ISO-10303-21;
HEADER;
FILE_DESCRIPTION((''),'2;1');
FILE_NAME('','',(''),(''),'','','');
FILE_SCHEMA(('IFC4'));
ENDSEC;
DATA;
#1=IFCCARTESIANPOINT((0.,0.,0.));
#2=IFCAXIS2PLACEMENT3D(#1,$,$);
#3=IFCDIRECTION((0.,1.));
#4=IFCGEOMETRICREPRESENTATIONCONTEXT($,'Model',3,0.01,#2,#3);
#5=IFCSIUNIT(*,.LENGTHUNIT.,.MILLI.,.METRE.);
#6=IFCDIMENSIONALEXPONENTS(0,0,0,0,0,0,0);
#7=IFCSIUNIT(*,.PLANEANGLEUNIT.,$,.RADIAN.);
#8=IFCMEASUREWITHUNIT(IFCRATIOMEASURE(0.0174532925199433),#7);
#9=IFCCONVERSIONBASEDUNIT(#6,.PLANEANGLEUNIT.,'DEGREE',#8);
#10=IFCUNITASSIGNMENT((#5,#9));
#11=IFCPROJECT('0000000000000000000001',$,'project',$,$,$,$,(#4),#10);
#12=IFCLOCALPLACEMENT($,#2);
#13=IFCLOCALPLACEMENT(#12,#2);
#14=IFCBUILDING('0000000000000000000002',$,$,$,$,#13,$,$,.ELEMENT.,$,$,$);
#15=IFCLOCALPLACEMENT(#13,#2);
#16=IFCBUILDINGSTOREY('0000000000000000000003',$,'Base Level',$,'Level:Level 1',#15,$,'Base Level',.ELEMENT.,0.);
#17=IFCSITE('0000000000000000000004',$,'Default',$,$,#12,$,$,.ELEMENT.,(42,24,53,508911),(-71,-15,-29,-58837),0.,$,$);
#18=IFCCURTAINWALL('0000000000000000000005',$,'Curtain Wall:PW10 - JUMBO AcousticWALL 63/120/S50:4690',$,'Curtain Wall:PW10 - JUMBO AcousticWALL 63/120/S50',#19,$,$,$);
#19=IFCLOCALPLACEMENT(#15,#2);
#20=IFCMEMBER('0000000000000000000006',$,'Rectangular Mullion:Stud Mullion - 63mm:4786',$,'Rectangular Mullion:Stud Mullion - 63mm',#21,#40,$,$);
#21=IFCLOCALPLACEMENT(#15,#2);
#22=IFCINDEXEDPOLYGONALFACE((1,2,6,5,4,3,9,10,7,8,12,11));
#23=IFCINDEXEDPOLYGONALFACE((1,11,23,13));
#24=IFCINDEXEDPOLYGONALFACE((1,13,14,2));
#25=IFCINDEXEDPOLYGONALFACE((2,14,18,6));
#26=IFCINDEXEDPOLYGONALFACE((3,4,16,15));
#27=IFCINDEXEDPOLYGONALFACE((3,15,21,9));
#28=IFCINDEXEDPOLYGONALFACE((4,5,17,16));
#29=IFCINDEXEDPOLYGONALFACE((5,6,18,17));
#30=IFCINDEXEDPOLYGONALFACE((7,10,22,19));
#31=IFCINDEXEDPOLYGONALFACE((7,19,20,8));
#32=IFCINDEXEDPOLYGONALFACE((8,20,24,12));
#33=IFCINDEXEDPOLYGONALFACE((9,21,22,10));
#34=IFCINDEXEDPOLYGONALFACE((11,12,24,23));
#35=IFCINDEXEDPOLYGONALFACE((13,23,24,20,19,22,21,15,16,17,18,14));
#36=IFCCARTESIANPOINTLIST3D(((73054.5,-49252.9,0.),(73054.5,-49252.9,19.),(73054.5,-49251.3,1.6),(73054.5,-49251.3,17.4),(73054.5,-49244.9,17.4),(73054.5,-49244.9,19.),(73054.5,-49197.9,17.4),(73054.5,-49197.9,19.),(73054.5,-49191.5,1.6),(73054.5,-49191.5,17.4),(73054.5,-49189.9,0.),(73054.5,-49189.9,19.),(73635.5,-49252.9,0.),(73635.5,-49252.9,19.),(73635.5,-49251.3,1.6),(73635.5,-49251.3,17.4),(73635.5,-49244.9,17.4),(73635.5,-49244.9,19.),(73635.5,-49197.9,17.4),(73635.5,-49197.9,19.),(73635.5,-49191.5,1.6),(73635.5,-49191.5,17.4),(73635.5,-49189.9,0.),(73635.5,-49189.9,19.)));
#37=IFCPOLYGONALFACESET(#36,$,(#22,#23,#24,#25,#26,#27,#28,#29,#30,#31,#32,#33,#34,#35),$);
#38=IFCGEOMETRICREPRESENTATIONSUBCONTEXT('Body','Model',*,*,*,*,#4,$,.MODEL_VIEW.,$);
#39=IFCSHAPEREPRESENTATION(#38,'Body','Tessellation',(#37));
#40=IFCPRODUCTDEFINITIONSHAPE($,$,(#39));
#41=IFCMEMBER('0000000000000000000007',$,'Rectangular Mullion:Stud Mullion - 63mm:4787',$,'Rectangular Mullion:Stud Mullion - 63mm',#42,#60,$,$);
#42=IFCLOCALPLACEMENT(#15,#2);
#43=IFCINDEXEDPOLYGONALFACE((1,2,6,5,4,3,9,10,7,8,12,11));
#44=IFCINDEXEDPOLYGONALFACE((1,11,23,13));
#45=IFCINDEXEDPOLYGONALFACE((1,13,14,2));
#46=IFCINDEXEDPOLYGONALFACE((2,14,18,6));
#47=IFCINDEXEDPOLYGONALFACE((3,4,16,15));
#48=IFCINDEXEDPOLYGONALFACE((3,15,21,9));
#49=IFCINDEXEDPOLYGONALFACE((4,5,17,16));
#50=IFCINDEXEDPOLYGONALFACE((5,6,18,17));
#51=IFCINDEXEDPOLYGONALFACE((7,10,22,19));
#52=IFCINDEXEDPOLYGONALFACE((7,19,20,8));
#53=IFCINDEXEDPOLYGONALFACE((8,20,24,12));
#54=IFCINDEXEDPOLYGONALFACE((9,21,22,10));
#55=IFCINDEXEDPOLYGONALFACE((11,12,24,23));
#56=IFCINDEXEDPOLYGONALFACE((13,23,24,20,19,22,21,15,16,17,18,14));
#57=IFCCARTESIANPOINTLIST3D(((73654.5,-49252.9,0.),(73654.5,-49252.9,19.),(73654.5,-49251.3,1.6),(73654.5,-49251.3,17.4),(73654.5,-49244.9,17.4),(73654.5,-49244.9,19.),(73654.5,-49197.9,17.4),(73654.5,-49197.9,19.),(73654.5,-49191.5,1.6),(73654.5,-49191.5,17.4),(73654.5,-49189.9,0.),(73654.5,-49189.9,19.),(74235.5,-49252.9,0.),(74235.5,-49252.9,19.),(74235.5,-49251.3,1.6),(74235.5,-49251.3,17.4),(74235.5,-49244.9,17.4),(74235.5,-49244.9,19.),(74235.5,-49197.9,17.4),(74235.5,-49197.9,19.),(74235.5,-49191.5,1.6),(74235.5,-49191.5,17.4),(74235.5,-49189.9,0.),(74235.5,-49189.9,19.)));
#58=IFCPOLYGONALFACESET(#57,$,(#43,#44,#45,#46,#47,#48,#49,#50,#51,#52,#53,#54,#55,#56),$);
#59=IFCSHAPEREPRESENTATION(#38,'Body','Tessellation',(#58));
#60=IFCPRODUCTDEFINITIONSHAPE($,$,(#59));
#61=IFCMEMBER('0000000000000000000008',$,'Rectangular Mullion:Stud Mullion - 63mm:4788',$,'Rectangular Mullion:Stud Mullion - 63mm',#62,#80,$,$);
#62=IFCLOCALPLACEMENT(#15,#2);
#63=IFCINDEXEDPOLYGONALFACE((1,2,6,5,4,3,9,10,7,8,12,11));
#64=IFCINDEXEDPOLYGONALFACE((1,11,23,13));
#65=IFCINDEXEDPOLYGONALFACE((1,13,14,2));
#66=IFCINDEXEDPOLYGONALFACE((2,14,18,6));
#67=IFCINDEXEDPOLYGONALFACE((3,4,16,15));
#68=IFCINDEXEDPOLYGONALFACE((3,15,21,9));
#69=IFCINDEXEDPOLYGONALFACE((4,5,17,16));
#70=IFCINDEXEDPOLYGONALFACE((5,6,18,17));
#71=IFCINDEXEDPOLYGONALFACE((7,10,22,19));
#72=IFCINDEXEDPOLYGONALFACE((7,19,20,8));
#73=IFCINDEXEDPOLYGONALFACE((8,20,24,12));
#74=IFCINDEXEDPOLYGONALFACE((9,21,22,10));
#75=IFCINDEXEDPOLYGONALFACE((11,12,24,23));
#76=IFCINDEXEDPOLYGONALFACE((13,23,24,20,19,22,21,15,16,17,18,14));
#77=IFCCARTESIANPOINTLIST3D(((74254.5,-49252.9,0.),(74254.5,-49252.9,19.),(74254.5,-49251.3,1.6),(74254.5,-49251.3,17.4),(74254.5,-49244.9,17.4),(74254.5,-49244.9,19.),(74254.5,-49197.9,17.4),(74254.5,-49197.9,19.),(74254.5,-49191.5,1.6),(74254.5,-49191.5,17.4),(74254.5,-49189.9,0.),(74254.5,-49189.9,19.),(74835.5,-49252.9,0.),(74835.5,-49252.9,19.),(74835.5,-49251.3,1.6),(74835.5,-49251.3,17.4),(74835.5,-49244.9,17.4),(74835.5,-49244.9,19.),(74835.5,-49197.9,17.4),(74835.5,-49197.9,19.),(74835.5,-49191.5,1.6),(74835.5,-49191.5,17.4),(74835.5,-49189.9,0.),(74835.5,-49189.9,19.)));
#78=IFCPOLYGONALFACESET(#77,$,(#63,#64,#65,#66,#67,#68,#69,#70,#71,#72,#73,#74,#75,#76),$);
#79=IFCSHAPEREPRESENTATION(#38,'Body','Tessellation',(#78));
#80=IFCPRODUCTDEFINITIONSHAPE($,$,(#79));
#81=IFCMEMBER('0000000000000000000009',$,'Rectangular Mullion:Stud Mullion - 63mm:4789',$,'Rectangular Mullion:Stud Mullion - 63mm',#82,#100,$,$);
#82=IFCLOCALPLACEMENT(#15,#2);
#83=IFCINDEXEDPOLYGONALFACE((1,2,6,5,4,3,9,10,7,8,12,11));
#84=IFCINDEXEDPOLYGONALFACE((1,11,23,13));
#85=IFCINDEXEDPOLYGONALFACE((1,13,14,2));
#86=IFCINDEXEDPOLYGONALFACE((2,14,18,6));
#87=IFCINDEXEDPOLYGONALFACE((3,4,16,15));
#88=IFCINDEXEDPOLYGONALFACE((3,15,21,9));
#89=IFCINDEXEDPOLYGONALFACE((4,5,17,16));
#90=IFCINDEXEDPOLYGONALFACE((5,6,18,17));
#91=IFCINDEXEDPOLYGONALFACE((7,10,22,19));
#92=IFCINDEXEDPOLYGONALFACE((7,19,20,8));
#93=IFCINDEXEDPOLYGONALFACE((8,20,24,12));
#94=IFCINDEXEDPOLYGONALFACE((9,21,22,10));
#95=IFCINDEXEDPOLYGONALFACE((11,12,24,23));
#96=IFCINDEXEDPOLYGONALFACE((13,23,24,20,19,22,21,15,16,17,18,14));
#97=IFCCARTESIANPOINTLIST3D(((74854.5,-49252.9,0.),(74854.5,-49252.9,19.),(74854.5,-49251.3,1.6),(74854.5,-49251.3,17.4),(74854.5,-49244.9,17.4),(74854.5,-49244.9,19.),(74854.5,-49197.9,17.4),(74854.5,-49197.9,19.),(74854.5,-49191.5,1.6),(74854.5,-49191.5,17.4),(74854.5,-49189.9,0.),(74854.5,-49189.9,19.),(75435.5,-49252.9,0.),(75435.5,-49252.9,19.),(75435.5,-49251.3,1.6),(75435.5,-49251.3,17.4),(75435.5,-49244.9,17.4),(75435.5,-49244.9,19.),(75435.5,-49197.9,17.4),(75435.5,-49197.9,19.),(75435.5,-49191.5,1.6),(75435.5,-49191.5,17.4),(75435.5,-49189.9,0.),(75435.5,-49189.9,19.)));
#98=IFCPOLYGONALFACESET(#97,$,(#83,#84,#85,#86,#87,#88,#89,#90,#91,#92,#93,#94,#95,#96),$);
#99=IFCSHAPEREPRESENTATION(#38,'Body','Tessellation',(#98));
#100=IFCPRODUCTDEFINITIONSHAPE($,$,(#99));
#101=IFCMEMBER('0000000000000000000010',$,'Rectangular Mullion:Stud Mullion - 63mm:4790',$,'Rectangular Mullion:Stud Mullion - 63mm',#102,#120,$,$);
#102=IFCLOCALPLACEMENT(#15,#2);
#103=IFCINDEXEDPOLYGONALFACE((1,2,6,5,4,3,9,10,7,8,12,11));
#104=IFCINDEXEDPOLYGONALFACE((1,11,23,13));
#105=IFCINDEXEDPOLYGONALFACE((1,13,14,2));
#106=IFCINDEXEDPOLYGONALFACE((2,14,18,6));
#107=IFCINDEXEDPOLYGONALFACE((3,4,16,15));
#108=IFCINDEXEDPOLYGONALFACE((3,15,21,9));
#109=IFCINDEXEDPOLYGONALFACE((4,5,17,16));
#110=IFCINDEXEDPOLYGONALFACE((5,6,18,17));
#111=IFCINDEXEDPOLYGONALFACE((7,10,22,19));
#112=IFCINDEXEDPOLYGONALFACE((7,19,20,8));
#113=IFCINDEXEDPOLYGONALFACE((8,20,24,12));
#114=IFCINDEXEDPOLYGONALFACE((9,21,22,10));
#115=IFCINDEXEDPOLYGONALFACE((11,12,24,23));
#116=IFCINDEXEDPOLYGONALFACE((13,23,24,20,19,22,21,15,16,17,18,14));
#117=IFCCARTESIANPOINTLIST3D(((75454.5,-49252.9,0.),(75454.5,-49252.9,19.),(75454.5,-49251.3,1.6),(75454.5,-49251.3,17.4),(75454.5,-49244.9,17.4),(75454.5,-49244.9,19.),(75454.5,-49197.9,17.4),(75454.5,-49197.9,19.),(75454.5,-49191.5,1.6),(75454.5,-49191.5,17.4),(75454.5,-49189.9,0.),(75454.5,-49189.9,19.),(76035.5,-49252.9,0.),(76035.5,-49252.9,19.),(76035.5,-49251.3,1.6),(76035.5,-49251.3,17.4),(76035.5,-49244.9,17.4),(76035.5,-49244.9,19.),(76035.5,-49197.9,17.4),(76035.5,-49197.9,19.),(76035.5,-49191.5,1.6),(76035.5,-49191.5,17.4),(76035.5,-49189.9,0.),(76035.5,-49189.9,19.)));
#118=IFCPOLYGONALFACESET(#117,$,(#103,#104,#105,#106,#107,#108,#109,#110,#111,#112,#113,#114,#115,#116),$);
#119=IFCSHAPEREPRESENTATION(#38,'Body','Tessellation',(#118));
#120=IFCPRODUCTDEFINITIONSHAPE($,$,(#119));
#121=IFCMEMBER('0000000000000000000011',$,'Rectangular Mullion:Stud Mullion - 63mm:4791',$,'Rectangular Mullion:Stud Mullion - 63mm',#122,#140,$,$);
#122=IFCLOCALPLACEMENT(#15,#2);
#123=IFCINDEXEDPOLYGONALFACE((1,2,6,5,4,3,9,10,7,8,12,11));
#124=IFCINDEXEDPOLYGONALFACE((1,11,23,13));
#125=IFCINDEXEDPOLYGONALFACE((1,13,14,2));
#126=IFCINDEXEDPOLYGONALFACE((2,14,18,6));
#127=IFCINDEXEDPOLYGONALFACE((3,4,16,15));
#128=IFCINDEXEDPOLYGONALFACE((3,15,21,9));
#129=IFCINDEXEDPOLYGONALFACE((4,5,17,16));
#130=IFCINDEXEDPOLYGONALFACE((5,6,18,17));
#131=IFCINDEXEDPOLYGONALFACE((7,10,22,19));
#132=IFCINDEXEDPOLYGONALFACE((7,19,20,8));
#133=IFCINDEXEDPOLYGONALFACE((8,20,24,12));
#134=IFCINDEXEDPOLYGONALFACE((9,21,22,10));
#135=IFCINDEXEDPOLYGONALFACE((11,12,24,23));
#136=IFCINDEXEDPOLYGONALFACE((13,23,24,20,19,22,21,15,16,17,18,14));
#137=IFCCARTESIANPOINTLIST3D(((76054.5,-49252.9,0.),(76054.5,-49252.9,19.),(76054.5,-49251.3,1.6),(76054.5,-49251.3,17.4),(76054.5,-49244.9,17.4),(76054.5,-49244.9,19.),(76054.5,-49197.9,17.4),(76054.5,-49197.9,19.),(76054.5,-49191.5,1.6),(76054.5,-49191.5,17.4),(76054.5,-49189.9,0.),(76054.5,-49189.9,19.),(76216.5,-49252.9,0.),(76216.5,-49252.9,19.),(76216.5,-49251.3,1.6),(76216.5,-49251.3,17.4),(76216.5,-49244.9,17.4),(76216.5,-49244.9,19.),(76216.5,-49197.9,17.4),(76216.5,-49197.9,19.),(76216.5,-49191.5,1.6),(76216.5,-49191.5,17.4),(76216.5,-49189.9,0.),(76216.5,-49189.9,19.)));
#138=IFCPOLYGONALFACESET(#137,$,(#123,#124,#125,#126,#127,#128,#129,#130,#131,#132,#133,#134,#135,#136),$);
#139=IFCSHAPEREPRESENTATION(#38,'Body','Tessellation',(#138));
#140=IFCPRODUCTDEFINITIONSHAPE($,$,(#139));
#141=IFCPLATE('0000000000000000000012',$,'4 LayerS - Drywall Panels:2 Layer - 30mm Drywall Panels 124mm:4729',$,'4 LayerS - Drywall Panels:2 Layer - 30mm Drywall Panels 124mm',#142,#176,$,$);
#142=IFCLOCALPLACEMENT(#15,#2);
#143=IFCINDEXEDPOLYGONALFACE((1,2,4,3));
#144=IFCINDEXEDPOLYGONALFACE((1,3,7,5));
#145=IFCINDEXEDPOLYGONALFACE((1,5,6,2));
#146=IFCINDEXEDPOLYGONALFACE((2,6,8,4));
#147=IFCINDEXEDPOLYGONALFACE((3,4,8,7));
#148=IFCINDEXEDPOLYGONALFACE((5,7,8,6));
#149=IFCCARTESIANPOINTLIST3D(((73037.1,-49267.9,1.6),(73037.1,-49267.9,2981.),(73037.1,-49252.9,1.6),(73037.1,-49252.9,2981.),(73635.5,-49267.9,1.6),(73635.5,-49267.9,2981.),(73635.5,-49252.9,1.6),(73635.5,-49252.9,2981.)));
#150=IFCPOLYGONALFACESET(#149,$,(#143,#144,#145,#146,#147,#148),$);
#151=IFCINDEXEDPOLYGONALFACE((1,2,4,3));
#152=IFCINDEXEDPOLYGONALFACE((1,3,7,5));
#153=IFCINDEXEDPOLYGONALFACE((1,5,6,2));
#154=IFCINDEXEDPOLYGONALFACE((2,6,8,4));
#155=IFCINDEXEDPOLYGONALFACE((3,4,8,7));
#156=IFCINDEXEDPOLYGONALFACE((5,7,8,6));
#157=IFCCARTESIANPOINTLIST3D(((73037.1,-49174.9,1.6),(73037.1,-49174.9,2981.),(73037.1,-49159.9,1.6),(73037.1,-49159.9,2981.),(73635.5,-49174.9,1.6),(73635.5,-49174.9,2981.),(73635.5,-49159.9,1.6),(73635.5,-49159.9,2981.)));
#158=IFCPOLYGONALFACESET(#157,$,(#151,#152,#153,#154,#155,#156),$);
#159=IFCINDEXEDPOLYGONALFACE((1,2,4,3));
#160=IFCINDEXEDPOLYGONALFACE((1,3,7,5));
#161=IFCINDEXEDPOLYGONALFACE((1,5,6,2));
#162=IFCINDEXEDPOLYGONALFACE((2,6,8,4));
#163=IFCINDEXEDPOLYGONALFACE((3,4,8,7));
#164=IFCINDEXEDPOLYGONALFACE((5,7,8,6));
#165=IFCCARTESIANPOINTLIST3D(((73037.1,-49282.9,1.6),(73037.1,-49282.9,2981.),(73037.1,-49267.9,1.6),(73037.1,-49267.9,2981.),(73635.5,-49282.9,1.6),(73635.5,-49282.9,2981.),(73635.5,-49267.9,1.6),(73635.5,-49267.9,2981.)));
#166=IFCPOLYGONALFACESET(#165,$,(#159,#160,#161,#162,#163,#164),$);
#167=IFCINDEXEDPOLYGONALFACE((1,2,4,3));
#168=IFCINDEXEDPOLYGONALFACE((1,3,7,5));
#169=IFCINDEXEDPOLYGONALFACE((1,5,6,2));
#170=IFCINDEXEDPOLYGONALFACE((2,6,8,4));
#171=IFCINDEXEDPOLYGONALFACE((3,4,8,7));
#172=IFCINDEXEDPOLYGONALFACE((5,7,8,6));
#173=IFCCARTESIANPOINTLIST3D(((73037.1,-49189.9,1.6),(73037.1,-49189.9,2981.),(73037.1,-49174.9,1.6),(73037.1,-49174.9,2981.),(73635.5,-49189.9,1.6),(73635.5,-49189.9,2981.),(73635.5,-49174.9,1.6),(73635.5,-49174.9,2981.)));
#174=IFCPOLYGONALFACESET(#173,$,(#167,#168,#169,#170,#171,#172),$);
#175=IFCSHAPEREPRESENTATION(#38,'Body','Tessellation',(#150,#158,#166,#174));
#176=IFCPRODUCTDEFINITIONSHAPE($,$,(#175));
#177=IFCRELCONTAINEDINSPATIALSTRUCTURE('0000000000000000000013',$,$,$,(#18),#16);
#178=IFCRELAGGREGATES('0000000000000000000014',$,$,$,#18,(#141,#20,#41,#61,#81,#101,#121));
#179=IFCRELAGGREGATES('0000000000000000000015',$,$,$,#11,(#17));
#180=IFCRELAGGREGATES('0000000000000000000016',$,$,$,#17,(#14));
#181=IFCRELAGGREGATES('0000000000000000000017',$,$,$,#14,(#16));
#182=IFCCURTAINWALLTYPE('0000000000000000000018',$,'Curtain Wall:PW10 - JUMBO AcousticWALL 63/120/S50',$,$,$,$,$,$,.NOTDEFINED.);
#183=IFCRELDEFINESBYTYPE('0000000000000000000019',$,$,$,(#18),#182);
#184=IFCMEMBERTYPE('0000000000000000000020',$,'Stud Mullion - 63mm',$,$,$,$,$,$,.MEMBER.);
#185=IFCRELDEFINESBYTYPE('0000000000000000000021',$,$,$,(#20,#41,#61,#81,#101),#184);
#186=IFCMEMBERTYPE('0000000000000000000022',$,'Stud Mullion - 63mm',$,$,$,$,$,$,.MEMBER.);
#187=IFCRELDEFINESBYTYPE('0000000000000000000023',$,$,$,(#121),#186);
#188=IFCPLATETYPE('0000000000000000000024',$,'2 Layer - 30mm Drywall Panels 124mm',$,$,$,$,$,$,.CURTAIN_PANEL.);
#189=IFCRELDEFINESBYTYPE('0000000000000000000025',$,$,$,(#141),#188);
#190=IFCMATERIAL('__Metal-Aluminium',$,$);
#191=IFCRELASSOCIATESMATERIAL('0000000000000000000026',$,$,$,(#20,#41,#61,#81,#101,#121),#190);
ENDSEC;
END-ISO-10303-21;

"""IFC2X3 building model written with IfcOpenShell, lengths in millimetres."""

from ifc_helpers import new_model, entity, si_unit, converted_unit, direction, frame, frame_2d, origin, origin_2d_with_axis, place, context, subcontext, project, spatial, polyline, rectangle, outline, extrude, source, transform, mapped, material, type_object, type_shapes, element, aggregate, save


model = new_model("IFC2X3")

# Units and contexts
model_context = context("Model", 3, precision=0.01, world=origin(), true_north=direction((0.0, 1.0)))
body_context = subcontext(model_context, "Body", "Model", "MODEL_VIEW")
ifc_project = project(units=[si_unit("LENGTHUNIT", "METRE", prefix="MILLI"), converted_unit("PLANEANGLEUNIT", "DEGREE", entity("IfcRatioMeasure", 0.0174532925199433), si_unit("PLANEANGLEUNIT", "RADIAN"), dimensions=[0, 0, 0, 0, 0, 0, 0])], contexts=[model_context])

# Site, building, storey
site_placement = place(None, origin())
site = spatial("IfcSite", under=ifc_project, at=site_placement, Name="Default", CompositionType="ELEMENT", RefLatitude=(42, 24, 53, 508911), RefLongitude=(-71, -15, -29, -58837), RefElevation=0.0)
building_placement = place(site_placement, origin())
building = spatial("IfcBuilding", under=site, at=building_placement, CompositionType="ELEMENT")
storey_placement = place(building_placement, origin())
storey = spatial("IfcBuildingStorey", under=building, at=storey_placement, Name="Base Level", ObjectType="Level:Level 1", LongName="Base Level", CompositionType="ELEMENT", Elevation=0.0)

# Curtain wall, members, plate
curtain_wall_type = type_object("IfcCurtainWallType", Name="Curtain Wall:PW10 - JUMBO AcousticWALL 63/120/S50", PredefinedType="NOTDEFINED")
curtain_wall_placement = place(building_placement, origin())
curtain_wall = element("IfcCurtainWall", 1, at=curtain_wall_placement, inside=storey, type_object=curtain_wall_type, Name="Curtain Wall:PW10 - JUMBO AcousticWALL 63/120/S50:4690", ObjectType="Curtain Wall:PW10 - JUMBO AcousticWALL 63/120/S50")
ifc_material = material(Name="__Metal-Aluminium")
member_type_1 = type_object("IfcMemberType", Name="Stud Mullion - 63mm", PredefinedType="MEMBER")
shared_shape_1 = source(origin(), body_context, "Body", "SweptSolid", [
    extrude(outline(polyline([(23.5, -6.6), (31.5, -6.6), (31.5, 12.4), (-31.5, 12.4), (-31.5, -6.6), (-23.5, -6.6), (-23.5, -5.0), (-29.9, -5.0), (-29.9, 10.8), (29.9, 10.8), (29.9, -5.0), (23.5, -5.0), (23.5, -6.6)])), frame((-12.4, 0.0, -581.0), z_axis=(0.0, 0.0, 1.0), x_axis=(0.0, -1.0, 0.0)), (0.0, 0.0, 1.0), 581.0),
])
type_shapes(member_type_1, [shared_shape_1])
member_1_placement = place(building_placement, frame((73054.5, -49221.4, 0.0), z_axis=(-1.0, 0.0, 0.0), x_axis=(0.0, 0.0, -1.0)))
member_1 = element("IfcMember", 2, at=member_1_placement, type_object=member_type_1, material=ifc_material, Name="Rectangular Mullion:Stud Mullion - 63mm:4786", ObjectType="Rectangular Mullion:Stud Mullion - 63mm", context=body_context, shape_type="MappedRepresentation", body=[
    mapped(shared_shape_1, transform((0.0, 0.0, 0.0), scale=1.0)),
])
member_2_placement = place(building_placement, frame((73654.5, -49221.4, 0.0), z_axis=(-1.0, 0.0, 0.0), x_axis=(0.0, 0.0, -1.0)))
member_2 = element("IfcMember", 3, at=member_2_placement, type_object=member_type_1, material=ifc_material, Name="Rectangular Mullion:Stud Mullion - 63mm:4787", ObjectType="Rectangular Mullion:Stud Mullion - 63mm", context=body_context, shape_type="MappedRepresentation", body=[
    mapped(shared_shape_1, transform((0.0, 0.0, 0.0), scale=1.0)),
])
member_3_placement = place(building_placement, frame((74254.5, -49221.4, 0.0), z_axis=(-1.0, 0.0, 0.0), x_axis=(0.0, 0.0, -1.0)))
member_3 = element("IfcMember", 4, at=member_3_placement, type_object=member_type_1, material=ifc_material, Name="Rectangular Mullion:Stud Mullion - 63mm:4788", ObjectType="Rectangular Mullion:Stud Mullion - 63mm", context=body_context, shape_type="MappedRepresentation", body=[
    mapped(shared_shape_1, transform((0.0, 0.0, 0.0), scale=1.0)),
])
member_4_placement = place(building_placement, frame((74854.5, -49221.4, 0.0), z_axis=(-1.0, 0.0, 0.0), x_axis=(0.0, 0.0, -1.0)))
member_4 = element("IfcMember", 5, at=member_4_placement, type_object=member_type_1, material=ifc_material, Name="Rectangular Mullion:Stud Mullion - 63mm:4789", ObjectType="Rectangular Mullion:Stud Mullion - 63mm", context=body_context, shape_type="MappedRepresentation", body=[
    mapped(shared_shape_1, transform((0.0, 0.0, 0.0), scale=1.0)),
])
member_5_placement = place(building_placement, frame((75454.5, -49221.4, 0.0), z_axis=(-1.0, 0.0, 0.0), x_axis=(0.0, 0.0, -1.0)))
member_5 = element("IfcMember", 6, at=member_5_placement, type_object=member_type_1, material=ifc_material, Name="Rectangular Mullion:Stud Mullion - 63mm:4790", ObjectType="Rectangular Mullion:Stud Mullion - 63mm", context=body_context, shape_type="MappedRepresentation", body=[
    mapped(shared_shape_1, transform((0.0, 0.0, 0.0), scale=1.0)),
])
member_type_2 = type_object("IfcMemberType", Name="Stud Mullion - 63mm", PredefinedType="MEMBER")
shared_shape_2 = source(origin(), body_context, "Body", "SweptSolid", [
    extrude(outline(polyline([(23.5, -6.6), (31.5, -6.6), (31.5, 12.4), (-31.5, 12.4), (-31.5, -6.6), (-23.5, -6.6), (-23.5, -5.0), (-29.9, -5.0), (-29.9, 10.8), (29.9, 10.8), (29.9, -5.0), (23.5, -5.0), (23.5, -6.6)])), frame((-12.4, 0.0, -162.0), z_axis=(0.0, 0.0, 1.0), x_axis=(0.0, -1.0, 0.0)), (0.0, 0.0, 1.0), 162.0),
])
type_shapes(member_type_2, [shared_shape_2])
member_6_placement = place(building_placement, frame((76054.5, -49221.4, 0.0), z_axis=(-1.0, 0.0, 0.0), x_axis=(0.0, 0.0, -1.0)))
member_6 = element("IfcMember", 7, at=member_6_placement, type_object=member_type_2, material=ifc_material, Name="Rectangular Mullion:Stud Mullion - 63mm:4791", ObjectType="Rectangular Mullion:Stud Mullion - 63mm", context=body_context, shape_type="MappedRepresentation", body=[
    mapped(shared_shape_2, transform((0.0, 0.0, 0.0), scale=1.0)),
])
plate_type_1 = type_object("IfcPlateType", Name="2 Layer - 30mm Drywall Panels 124mm", PredefinedType="CURTAIN_PANEL")
shared_shape_3 = source(origin(), body_context, "Body", "SweptSolid", [
    extrude(rectangle(XDim=15.0, YDim=598.4, at=origin_2d_with_axis()), frame((0.0, -39.0, 0.0), z_axis=(0.0, 0.0, 1.0), x_axis=(0.0, 1.0, 0.0)), (0.0, 0.0, 1.0), 2979.4),
    extrude(rectangle(XDim=15.0, YDim=598.4, at=origin_2d_with_axis()), frame((0.0, 54.0, 0.0), z_axis=(0.0, 0.0, 1.0), x_axis=(0.0, 1.0, 0.0)), (0.0, 0.0, 1.0), 2979.4),
    extrude(rectangle(XDim=598.4, YDim=15.0, at=frame_2d((0.0, 0.0), x_axis=(1.0, 0.0))), frame((0.0, -54.0, 0.0), z_axis=(0.0, 0.0, 1.0), x_axis=(-1.0, 0.0, 0.0)), (0.0, 0.0, 1.0), 2979.4),
    extrude(rectangle(XDim=15.0, YDim=598.4, at=frame_2d((0.0, 0.0), x_axis=(1.0, 0.0))), frame((0.0, 39.0, 0.0), z_axis=(0.0, 0.0, 1.0), x_axis=(0.0, 1.0, 0.0)), (0.0, 0.0, 1.0), 2979.4),
])
type_shapes(plate_type_1, [shared_shape_3])
plate_1_placement = place(curtain_wall_placement, frame((73336.3, -49221.4, 1.6)))
plate_1 = element("IfcPlate", 8, at=plate_1_placement, type_object=plate_type_1, Name="4 LayerS - Drywall Panels:2 Layer - 30mm Drywall Panels 124mm:4729", ObjectType="4 LayerS - Drywall Panels:2 Layer - 30mm Drywall Panels 124mm", context=body_context, shape_type="MappedRepresentation", body=[
    mapped(shared_shape_3, transform((0.0, 0.0, 0.0), scale=1.0)),
])
aggregate(curtain_wall, [plate_1, member_1, member_2, member_3, member_4, member_5, member_6])

save(model, "model.ifc")
